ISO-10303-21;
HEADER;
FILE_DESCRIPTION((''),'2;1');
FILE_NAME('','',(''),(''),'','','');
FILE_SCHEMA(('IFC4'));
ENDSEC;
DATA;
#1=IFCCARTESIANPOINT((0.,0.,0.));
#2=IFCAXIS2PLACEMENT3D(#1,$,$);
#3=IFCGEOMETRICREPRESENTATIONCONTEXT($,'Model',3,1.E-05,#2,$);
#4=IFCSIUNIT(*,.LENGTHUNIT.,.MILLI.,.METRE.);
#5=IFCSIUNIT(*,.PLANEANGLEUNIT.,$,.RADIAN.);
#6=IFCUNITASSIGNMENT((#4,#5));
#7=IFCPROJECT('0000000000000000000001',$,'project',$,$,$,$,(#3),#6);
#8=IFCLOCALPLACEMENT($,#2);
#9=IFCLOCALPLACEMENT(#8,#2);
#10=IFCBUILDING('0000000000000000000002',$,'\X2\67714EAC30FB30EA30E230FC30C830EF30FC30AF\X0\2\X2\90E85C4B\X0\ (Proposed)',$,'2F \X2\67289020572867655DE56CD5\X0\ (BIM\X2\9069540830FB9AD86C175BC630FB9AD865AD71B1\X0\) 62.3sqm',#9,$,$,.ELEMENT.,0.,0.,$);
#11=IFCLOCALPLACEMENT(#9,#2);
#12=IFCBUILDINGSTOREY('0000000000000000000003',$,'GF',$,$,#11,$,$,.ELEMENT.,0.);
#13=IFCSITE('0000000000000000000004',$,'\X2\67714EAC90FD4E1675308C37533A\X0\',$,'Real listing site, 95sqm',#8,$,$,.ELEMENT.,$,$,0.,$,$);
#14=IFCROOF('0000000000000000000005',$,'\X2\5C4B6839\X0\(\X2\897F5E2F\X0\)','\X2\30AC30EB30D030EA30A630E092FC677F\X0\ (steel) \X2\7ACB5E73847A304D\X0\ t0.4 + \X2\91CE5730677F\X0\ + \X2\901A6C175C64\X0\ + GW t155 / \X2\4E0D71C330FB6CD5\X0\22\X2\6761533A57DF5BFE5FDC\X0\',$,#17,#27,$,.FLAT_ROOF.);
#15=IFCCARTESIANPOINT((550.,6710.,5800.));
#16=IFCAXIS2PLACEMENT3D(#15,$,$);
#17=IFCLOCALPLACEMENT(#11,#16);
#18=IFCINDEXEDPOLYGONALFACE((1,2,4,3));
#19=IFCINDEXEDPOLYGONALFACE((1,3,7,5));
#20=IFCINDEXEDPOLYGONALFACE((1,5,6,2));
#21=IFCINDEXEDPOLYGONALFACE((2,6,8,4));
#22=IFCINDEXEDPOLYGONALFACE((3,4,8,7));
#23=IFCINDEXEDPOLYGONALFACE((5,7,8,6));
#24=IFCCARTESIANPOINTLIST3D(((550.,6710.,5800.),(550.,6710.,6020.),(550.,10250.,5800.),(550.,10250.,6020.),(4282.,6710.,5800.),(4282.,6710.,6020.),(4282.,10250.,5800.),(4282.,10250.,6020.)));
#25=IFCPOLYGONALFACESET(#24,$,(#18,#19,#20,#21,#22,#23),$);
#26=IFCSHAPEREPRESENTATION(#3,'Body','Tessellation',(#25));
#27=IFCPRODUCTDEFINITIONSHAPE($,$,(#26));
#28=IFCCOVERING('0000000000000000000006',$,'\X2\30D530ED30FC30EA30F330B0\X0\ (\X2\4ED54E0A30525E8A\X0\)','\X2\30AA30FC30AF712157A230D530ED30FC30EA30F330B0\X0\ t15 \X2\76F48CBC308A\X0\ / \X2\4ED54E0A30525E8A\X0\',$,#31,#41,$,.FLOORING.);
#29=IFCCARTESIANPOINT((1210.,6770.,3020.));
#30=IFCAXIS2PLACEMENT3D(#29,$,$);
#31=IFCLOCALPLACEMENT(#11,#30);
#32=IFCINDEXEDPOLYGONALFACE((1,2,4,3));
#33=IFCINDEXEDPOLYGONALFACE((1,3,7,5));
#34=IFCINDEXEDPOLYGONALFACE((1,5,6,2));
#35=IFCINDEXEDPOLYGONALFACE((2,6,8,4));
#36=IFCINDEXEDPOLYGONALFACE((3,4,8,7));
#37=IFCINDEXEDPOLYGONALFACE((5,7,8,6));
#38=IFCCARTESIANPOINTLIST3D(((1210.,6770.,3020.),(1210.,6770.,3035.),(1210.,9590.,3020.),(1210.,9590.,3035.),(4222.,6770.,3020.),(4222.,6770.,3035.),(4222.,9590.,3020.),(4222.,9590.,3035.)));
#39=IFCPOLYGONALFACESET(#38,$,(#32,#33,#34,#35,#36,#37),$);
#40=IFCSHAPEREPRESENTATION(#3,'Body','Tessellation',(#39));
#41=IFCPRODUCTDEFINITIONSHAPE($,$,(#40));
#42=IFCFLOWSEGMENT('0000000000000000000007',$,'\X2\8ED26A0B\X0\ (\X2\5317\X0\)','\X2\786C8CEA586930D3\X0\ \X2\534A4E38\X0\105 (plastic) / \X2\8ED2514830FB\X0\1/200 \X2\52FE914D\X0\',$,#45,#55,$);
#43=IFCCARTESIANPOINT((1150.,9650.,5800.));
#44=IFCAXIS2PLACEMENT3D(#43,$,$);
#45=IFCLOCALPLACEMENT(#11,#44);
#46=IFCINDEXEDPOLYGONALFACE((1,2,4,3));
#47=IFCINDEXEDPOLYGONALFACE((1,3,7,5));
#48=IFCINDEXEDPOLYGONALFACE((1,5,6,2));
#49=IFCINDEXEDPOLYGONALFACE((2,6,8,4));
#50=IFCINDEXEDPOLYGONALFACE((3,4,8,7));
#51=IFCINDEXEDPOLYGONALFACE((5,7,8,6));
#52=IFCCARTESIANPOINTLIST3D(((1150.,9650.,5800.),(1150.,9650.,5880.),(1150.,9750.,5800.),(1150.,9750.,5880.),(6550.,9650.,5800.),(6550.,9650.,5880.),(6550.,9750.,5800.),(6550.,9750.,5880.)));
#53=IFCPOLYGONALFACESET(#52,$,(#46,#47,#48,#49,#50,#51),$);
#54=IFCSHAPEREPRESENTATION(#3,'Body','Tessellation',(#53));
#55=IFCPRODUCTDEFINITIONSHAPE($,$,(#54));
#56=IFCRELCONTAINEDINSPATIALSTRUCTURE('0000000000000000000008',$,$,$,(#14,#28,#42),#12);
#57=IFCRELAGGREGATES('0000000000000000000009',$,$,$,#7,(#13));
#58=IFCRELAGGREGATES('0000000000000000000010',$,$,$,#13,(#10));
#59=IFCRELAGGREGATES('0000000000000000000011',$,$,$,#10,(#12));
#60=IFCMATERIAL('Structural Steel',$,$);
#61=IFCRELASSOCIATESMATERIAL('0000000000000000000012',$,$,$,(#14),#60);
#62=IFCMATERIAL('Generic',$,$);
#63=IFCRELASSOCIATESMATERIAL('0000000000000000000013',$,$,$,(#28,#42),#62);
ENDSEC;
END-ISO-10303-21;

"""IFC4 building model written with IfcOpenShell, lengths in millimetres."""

from ifc_helpers import new_model, si_unit, frame, frame_2d, origin, place, context, project, spatial, rectangle, extrude, material, element, save


model = new_model("IFC4")

# Units and contexts
model_context = context("Model", 3, precision=1e-05, world=origin())
ifc_project = project(units=[si_unit("LENGTHUNIT", "METRE", prefix="MILLI"), si_unit("PLANEANGLEUNIT", "RADIAN")], contexts=[model_context])

# Site, building, storey
site_placement = place(None, origin())
site = spatial("IfcSite", under=ifc_project, at=site_placement, Name="東京都世田谷区", ObjectType="Real listing site, 95sqm", CompositionType="ELEMENT", RefElevation=0.0)
building_placement = place(site_placement, origin())
building = spatial("IfcBuilding", under=site, at=building_placement, Name="東京・リモートワーク2部屋 (Proposed)", ObjectType="2F 木造在来工法 (BIM適合・高気密・高断熱) 62.3sqm", CompositionType="ELEMENT", ElevationOfRefHeight=0.0, ElevationOfTerrain=0.0)
storey_placement = place(building_placement, origin())
storey = spatial("IfcBuildingStorey", under=building, at=storey_placement, Name="GF", CompositionType="ELEMENT", Elevation=0.0)

# Roof
ifc_material_1 = material(Name="Structural Steel")
for number, where, name in (
    (1, (550.0, 6710.0, 5800.0), "屋根(西帯)"),
):
    element("IfcRoof", number, at=place(storey_placement, frame(where)), inside=storey, material=ifc_material_1, Name=name, Description="ガルバリウム鋼板 (steel) 立平葺き t0.4 + 野地板 + 通気層 + GW t155 / 不燃・法22条区域対応", PredefinedType="FLAT_ROOF", context=model_context, shape_type="SweptSolid", body=[
        extrude(rectangle(XDim=3732.0, YDim=3540.0, at=frame_2d((1866.0, 1770.0))), frame((550.0, 6710.0, 5800.0)), (0.0, 0.0, 1.0), 220.0),
    ])

# Covering
ifc_material_2 = material(Name="Generic")
covering_placement = place(storey_placement, frame((1210.0, 6770.0, 3020.0)))
element("IfcCovering", 2, at=covering_placement, inside=storey, material=ifc_material_2, Name="フローリング (仕上げ床)", Description="オーク無垢フローリング t15 直貼り / 仕上げ床", PredefinedType="FLOORING", context=model_context, shape_type="SweptSolid", body=[
    extrude(rectangle(XDim=3012.0, YDim=2820.0, at=frame_2d((1506.0, 1410.0))), frame((1210.0, 6770.0, 3020.0)), (0.0, 0.0, 1.0), 15.0),
])

# Flow segment
flow_segment_placement = place(storey_placement, frame((1150.0, 9650.0, 5800.0)))
element("IfcFlowSegment", 3, at=flow_segment_placement, inside=storey, material=ifc_material_2, Name="軒樋 (北)", Description="硬質塩ビ 半丸105 (plastic) / 軒先・1/200 勾配", context=model_context, shape_type="SweptSolid", body=[
    extrude(rectangle(XDim=5400.0, YDim=100.0, at=frame_2d((2700.0, 50.0))), frame((1150.0, 9650.0, 5800.0)), (0.0, 0.0, 1.0), 80.0),
])

save(model, "model.ifc")
